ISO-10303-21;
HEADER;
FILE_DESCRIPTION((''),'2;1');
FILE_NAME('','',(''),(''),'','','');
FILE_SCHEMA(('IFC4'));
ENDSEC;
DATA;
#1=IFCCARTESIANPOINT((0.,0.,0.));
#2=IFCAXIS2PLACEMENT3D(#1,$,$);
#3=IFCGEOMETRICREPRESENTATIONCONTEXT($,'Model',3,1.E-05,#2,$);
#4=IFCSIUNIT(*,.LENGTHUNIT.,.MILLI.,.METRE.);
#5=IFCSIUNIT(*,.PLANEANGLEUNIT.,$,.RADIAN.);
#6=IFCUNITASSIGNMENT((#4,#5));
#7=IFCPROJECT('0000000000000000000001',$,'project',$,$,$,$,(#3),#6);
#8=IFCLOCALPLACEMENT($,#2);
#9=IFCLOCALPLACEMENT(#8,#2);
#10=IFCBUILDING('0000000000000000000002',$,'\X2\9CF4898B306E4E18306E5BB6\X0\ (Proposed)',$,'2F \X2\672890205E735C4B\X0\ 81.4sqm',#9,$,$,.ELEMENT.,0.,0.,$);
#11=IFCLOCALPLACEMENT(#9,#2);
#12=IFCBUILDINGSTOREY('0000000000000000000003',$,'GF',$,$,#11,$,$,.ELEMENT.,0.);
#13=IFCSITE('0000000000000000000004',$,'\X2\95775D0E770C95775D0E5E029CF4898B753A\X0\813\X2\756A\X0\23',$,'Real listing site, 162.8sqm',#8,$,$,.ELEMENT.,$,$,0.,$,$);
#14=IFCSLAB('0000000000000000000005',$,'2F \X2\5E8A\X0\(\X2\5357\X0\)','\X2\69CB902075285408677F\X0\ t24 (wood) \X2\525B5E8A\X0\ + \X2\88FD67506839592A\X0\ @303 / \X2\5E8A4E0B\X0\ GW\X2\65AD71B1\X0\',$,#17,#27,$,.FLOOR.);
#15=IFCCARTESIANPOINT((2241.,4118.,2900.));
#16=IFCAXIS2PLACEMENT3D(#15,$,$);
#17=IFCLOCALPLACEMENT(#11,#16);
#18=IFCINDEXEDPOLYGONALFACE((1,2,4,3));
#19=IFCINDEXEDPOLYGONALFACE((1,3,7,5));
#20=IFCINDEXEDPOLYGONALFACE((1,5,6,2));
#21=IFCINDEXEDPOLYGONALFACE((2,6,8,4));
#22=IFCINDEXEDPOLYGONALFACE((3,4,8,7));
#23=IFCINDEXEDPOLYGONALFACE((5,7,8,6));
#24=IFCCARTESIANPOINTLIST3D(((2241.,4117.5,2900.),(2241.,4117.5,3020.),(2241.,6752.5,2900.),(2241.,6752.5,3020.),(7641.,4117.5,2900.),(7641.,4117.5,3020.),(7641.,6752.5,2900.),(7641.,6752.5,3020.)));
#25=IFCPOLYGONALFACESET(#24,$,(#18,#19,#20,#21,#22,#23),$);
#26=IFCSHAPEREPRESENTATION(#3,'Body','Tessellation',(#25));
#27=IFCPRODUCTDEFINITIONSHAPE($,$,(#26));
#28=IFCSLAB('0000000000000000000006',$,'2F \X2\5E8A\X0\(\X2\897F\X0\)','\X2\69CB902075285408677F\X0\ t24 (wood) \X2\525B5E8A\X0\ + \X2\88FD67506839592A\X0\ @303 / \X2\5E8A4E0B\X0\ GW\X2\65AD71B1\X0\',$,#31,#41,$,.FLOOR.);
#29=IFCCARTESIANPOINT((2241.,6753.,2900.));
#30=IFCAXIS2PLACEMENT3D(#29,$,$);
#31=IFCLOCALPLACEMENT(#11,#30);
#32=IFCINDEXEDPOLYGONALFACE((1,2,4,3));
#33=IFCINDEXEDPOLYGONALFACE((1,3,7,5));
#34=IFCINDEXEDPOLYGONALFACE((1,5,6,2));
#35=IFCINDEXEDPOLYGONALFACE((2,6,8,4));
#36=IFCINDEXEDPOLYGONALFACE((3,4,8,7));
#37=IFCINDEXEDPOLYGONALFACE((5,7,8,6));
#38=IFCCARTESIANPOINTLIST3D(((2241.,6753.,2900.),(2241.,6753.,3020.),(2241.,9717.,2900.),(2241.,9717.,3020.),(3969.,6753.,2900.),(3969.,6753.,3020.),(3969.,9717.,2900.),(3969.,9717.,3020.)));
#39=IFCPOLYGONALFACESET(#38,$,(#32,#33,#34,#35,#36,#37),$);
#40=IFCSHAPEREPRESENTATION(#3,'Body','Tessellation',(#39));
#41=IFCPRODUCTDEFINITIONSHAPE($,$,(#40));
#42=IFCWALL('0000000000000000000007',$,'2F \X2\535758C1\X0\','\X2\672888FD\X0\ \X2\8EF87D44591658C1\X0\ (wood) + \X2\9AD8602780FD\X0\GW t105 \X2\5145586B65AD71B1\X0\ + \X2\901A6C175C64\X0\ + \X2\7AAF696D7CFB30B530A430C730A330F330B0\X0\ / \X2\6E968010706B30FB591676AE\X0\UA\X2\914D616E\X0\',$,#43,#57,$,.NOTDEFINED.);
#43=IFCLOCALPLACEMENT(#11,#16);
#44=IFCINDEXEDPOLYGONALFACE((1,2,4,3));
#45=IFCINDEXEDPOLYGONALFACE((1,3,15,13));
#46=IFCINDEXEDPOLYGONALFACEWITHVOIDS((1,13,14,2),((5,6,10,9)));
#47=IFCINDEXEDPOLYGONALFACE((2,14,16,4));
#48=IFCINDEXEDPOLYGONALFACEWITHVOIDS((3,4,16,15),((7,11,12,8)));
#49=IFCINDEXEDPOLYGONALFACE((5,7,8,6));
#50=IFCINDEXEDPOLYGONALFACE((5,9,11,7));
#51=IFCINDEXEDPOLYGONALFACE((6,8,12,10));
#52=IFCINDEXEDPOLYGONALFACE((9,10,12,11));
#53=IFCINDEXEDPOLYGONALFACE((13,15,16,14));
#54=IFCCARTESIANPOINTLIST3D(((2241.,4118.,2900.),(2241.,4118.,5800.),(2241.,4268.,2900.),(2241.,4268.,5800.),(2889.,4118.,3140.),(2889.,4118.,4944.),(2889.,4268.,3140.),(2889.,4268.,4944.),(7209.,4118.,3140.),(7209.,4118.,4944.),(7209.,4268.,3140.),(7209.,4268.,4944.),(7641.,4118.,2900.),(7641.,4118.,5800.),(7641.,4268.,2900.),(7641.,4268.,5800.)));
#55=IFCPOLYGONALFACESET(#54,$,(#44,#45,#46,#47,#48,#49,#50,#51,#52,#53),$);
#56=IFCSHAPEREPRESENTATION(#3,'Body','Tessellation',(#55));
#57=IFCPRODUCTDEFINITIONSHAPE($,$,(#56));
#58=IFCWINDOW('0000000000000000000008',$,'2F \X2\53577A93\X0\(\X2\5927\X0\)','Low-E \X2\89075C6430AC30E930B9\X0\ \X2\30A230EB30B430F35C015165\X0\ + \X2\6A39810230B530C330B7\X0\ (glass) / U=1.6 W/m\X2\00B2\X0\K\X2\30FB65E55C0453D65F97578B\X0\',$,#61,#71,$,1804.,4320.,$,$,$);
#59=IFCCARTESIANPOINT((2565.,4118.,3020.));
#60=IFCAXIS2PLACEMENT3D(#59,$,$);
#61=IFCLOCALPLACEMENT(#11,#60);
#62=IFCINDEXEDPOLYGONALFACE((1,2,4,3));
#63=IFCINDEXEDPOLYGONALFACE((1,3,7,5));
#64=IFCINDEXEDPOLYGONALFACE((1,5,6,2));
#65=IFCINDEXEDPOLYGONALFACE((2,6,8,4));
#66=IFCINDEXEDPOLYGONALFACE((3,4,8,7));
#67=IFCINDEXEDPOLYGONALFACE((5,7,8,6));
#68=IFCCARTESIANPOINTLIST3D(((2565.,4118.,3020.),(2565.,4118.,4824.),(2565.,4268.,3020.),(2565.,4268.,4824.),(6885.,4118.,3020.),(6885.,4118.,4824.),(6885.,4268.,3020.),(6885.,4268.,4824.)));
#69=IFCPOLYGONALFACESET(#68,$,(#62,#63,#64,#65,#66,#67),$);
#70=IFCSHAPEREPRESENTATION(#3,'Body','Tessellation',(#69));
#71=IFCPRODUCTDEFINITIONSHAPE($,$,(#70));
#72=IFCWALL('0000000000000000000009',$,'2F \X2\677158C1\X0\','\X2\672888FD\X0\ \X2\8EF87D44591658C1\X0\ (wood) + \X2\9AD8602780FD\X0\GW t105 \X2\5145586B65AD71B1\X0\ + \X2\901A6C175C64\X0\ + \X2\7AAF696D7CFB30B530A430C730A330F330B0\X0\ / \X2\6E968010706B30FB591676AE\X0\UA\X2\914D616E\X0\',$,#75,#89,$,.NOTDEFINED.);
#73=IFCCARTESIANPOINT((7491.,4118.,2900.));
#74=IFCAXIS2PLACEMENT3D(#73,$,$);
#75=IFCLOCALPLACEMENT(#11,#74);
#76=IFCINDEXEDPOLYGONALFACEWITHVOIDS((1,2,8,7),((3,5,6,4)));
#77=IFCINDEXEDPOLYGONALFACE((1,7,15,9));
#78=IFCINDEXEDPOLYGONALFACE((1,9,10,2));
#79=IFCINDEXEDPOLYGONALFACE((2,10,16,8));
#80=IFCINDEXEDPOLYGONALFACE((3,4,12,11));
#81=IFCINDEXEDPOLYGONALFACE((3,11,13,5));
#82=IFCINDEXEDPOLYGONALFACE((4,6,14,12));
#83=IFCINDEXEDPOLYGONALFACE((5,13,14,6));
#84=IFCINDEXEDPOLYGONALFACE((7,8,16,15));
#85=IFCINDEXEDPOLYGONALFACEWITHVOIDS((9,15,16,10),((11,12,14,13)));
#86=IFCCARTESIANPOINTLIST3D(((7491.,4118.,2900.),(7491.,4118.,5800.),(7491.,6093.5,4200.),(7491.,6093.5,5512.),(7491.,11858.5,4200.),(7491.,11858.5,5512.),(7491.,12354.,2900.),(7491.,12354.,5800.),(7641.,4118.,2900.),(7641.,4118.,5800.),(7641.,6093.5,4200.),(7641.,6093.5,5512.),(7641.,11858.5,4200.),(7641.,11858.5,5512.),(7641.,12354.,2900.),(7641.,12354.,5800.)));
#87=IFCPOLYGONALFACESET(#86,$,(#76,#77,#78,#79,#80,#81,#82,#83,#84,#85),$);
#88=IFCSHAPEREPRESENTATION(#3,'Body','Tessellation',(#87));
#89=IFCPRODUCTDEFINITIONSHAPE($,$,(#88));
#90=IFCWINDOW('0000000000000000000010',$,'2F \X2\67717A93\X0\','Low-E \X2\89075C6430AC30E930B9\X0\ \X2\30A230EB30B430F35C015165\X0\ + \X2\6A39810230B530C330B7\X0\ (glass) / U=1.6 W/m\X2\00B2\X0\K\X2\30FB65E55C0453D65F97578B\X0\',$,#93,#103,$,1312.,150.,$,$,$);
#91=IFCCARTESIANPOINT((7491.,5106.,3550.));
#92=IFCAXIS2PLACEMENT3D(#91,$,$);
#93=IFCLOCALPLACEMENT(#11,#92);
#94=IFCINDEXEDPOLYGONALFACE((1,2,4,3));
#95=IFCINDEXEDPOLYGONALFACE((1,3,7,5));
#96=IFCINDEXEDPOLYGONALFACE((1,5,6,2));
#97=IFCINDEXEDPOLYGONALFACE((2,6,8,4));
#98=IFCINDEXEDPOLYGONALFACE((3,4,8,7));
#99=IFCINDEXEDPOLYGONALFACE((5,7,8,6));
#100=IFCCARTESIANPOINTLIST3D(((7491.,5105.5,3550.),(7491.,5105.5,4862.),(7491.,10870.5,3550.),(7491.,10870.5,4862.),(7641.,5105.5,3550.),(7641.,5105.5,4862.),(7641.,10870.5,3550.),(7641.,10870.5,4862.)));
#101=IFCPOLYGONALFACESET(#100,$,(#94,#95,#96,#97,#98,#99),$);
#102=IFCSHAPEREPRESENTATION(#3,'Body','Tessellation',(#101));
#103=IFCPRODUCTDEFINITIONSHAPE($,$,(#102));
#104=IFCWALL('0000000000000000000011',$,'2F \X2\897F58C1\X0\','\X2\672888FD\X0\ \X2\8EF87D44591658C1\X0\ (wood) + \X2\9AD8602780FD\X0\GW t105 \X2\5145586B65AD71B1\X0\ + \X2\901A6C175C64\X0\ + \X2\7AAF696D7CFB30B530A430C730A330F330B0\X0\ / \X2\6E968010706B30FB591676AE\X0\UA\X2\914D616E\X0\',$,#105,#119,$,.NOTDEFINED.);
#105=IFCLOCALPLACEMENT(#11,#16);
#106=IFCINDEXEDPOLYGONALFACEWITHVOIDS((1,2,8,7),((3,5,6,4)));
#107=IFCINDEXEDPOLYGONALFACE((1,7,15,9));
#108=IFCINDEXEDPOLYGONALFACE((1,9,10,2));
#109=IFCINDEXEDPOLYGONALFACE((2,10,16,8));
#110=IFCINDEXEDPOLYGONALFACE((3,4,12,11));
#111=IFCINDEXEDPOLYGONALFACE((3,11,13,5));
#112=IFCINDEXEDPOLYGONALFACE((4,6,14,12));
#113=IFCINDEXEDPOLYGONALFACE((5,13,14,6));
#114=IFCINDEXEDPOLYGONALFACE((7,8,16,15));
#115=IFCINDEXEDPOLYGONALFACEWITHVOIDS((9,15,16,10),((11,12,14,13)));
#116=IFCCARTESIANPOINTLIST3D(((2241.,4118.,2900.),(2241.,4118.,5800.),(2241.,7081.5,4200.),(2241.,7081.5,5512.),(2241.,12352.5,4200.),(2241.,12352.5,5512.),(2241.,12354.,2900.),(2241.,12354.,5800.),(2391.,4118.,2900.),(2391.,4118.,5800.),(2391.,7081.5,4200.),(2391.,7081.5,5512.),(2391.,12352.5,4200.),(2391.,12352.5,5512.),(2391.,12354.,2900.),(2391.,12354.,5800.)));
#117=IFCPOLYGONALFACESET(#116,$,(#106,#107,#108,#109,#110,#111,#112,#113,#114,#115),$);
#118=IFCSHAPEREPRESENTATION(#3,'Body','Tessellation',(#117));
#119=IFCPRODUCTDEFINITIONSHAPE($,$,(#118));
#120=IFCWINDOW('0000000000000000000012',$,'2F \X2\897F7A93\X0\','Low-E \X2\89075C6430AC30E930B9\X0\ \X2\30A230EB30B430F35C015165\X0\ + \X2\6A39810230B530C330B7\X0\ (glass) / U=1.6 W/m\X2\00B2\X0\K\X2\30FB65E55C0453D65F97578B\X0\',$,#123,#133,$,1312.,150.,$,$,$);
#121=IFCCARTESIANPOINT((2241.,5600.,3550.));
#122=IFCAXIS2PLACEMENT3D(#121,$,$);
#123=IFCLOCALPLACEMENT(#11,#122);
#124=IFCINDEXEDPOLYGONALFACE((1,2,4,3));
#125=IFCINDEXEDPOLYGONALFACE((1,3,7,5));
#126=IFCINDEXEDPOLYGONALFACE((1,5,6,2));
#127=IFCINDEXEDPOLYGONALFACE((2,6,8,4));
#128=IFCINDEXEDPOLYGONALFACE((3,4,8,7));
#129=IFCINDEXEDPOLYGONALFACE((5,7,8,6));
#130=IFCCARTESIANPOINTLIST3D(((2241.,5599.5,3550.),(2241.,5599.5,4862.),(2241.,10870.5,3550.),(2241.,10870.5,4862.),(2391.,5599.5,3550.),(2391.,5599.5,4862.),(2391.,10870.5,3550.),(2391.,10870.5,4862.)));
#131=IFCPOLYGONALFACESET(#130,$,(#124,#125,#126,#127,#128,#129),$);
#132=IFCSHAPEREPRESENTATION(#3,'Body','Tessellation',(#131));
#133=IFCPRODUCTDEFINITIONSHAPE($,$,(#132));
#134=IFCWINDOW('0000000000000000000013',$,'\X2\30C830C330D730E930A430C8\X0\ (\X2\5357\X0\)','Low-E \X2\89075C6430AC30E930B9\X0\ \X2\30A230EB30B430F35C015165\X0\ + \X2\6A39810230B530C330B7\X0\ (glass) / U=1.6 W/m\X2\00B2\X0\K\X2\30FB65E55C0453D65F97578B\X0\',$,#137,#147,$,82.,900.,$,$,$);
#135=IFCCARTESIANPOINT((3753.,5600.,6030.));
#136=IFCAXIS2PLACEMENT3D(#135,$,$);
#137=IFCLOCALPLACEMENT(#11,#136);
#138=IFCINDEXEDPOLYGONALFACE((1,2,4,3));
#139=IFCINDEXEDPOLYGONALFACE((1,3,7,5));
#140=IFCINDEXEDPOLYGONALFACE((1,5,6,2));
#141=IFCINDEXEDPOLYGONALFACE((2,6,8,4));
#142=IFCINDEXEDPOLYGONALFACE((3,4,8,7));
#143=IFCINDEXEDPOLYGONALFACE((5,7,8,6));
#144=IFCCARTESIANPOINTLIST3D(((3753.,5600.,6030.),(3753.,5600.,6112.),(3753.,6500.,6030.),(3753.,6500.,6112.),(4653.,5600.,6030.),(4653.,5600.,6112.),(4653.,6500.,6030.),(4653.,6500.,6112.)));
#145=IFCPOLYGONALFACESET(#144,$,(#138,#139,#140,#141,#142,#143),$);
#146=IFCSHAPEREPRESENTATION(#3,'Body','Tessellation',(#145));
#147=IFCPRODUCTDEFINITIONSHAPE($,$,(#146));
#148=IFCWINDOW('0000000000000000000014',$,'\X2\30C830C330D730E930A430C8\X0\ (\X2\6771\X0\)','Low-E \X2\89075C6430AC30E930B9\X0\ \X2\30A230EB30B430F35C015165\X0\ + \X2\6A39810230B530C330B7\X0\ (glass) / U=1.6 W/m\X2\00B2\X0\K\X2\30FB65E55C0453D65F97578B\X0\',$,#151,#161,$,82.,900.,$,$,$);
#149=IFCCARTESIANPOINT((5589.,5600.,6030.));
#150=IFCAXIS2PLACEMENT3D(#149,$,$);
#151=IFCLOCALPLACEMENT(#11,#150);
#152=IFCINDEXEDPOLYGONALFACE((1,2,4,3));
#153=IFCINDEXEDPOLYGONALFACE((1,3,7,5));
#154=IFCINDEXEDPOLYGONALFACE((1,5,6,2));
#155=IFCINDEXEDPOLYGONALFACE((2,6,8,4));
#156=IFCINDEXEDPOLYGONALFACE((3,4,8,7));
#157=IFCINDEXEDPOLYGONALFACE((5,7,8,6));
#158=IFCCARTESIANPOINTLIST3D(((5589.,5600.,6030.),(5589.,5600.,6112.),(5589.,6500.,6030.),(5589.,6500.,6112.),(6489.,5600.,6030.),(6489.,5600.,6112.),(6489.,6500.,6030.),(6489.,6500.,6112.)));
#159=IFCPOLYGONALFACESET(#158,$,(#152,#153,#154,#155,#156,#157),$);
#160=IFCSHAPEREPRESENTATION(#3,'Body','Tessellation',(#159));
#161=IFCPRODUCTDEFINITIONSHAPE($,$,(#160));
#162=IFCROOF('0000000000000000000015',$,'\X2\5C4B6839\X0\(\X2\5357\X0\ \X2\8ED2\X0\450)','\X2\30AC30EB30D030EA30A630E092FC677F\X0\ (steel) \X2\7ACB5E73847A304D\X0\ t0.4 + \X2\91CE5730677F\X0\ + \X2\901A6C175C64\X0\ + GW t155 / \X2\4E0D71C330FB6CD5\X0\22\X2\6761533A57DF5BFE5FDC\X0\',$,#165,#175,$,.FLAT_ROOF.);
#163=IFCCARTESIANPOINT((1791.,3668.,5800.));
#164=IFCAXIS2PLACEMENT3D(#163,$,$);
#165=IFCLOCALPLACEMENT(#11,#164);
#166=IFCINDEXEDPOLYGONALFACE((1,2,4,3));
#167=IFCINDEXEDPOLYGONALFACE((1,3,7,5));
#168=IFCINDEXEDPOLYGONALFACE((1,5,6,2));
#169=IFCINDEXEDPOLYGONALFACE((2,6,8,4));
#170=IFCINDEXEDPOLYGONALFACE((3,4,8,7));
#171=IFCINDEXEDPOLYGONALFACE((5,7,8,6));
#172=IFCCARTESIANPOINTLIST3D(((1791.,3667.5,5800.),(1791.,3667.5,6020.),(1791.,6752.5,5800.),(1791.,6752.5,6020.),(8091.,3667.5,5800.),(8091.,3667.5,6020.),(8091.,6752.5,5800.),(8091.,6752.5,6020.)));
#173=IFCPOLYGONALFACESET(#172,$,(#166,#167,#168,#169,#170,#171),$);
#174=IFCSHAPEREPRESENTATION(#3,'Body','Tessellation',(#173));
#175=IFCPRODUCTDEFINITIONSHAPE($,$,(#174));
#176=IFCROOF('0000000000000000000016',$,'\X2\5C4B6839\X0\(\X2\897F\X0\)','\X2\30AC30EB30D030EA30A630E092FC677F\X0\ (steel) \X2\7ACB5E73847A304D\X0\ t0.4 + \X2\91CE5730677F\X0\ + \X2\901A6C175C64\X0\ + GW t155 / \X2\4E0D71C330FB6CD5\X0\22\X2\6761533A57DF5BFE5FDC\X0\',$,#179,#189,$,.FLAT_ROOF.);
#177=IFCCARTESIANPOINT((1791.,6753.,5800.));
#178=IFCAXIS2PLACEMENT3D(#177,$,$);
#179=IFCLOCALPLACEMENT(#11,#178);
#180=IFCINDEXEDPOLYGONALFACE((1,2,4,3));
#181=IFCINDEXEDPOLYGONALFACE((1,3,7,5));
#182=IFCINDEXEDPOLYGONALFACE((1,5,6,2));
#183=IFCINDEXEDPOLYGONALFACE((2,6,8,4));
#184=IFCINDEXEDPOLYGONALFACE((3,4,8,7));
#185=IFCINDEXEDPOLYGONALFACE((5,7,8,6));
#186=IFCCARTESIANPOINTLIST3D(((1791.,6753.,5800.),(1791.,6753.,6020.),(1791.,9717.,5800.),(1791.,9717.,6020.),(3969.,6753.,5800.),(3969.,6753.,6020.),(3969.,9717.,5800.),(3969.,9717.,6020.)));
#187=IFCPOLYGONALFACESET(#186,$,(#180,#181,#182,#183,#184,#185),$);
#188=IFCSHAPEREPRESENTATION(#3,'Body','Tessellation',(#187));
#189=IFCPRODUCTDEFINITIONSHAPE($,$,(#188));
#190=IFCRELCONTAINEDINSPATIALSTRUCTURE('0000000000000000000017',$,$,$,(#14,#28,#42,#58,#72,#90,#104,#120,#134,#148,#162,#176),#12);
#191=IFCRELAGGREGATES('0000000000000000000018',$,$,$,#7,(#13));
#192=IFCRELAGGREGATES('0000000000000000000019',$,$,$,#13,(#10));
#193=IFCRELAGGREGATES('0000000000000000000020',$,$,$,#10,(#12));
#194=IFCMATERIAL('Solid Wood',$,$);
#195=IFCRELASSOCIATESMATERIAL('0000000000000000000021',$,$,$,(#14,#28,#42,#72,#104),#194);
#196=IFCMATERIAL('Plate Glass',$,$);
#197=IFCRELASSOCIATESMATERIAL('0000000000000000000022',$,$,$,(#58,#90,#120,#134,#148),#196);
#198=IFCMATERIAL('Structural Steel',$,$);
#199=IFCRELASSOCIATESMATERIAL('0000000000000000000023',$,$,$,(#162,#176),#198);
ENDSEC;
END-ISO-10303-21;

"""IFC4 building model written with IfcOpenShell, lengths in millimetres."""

from ifc_helpers import new_model, si_unit, frame, frame_2d, origin, place, context, project, spatial, rectangle, extrude, material, element, fill, save


model = new_model("IFC4")

# Units and contexts
model_context = context("Model", 3, precision=1e-05, world=origin())
ifc_project = project(units=[si_unit("LENGTHUNIT", "METRE", prefix="MILLI"), si_unit("PLANEANGLEUNIT", "RADIAN")], contexts=[model_context])

# Site, building, storey
site_placement = place(None, origin())
site = spatial("IfcSite", under=ifc_project, at=site_placement, Name="長崎県長崎市鳴見町813番23", ObjectType="Real listing site, 162.8sqm", CompositionType="ELEMENT", RefElevation=0.0)
building_placement = place(site_placement, origin())
building = spatial("IfcBuilding", under=site, at=building_placement, Name="鳴見の丘の家 (Proposed)", ObjectType="2F 木造平屋 81.4sqm", CompositionType="ELEMENT", ElevationOfRefHeight=0.0, ElevationOfTerrain=0.0)
storey_placement = place(building_placement, origin())
storey = spatial("IfcBuildingStorey", under=building, at=storey_placement, Name="GF", CompositionType="ELEMENT", Elevation=0.0)

# Slabs
ifc_material_1 = material(Name="Solid Wood")
slab_1_placement = place(storey_placement, frame((2241.0, 4118.0, 2900.0)))
element("IfcSlab", 1, at=slab_1_placement, inside=storey, material=ifc_material_1, Name="2F 床(南)", Description="構造用合板 t24 (wood) 剛床 + 製材根太 @303 / 床下 GW断熱", PredefinedType="FLOOR", context=model_context, shape_type="SweptSolid", body=[
    extrude(rectangle(XDim=5400.0, YDim=2635.0, at=frame_2d((2700.0, 1317.0))), frame((2241.0, 4118.0, 2900.0)), (0.0, 0.0, 1.0), 120.0),
])
slab_2_placement = place(storey_placement, frame((2241.0, 6753.0, 2900.0)))
element("IfcSlab", 2, at=slab_2_placement, inside=storey, material=ifc_material_1, Name="2F 床(西)", Description="構造用合板 t24 (wood) 剛床 + 製材根太 @303 / 床下 GW断熱", PredefinedType="FLOOR", context=model_context, shape_type="SweptSolid", body=[
    extrude(rectangle(XDim=1728.0, YDim=2964.0, at=frame_2d((864.0, 1482.0))), frame((2241.0, 6753.0, 2900.0)), (0.0, 0.0, 1.0), 120.0),
])

# Walls, openings, windows
wall_1_placement = place(storey_placement, frame((2241.0, 4118.0, 2900.0)))
wall_1 = element("IfcWall", 3, at=wall_1_placement, inside=storey, material=ifc_material_1, Name="2F 南壁", Description="木製 軸組外壁 (wood) + 高性能GW t105 充填断熱 + 通気層 + 窯業系サイディング / 準耐火・外皮UA配慮", PredefinedType="NOTDEFINED", context=model_context, shape_type="SweptSolid", body=[
    extrude(rectangle(XDim=5400.0, YDim=150.0, at=frame_2d((2700.0, 75.0))), frame((2241.0, 4118.0, 2900.0)), (0.0, 0.0, 1.0), 2900.0),
])
opening_1_placement = place(storey_placement, frame((2565.0, 4118.0, 3020.0)))
opening_1 = element("IfcOpeningElement", 4, at=opening_1_placement, cuts=wall_1, PredefinedType="NOTDEFINED", context=model_context, shape_type="SweptSolid", body=[
    extrude(rectangle(XDim=4320.0, YDim=150.0, at=frame_2d((2160.0, 75.0))), frame((2565.0, 4118.0, 3020.0)), (0.0, 0.0, 1.0), 1804.0),
])
ifc_material_2 = material(Name="Plate Glass")
window_1_placement = place(storey_placement, frame((2565.0, 4118.0, 3020.0)))
window_1 = element("IfcWindow", 5, at=window_1_placement, inside=storey, material=ifc_material_2, Name="2F 南窓(大)", Description="Low-E 複層ガラス アルゴン封入 + 樹脂サッシ (glass) / U=1.6 W/m²K・日射取得型", OverallHeight=1804.0, OverallWidth=4320.0, context=model_context, shape_type="SweptSolid", body=[
    extrude(rectangle(XDim=4320.0, YDim=150.0, at=frame_2d((2160.0, 75.0))), frame((2565.0, 4118.0, 3020.0)), (0.0, 0.0, 1.0), 1804.0),
])
fill(opening_1, window_1)
wall_2_placement = place(storey_placement, frame((7491.0, 4118.0, 2900.0)))
wall_2 = element("IfcWall", 6, at=wall_2_placement, inside=storey, material=ifc_material_1, Name="2F 東壁", Description="木製 軸組外壁 (wood) + 高性能GW t105 充填断熱 + 通気層 + 窯業系サイディング / 準耐火・外皮UA配慮", PredefinedType="NOTDEFINED", context=model_context, shape_type="SweptSolid", body=[
    extrude(rectangle(XDim=150.0, YDim=8236.0, at=frame_2d((75.0, 4118.0))), frame((7491.0, 4118.0, 2900.0)), (0.0, 0.0, 1.0), 2900.0),
])
opening_2_placement = place(storey_placement, frame((7491.0, 5106.0, 3550.0)))
opening_2 = element("IfcOpeningElement", 7, at=opening_2_placement, cuts=wall_2, PredefinedType="NOTDEFINED", context=model_context, shape_type="SweptSolid", body=[
    extrude(rectangle(XDim=150.0, YDim=5765.0, at=frame_2d((75.0, 2882.0))), frame((7491.0, 5106.0, 3550.0)), (0.0, 0.0, 1.0), 1312.0),
])
window_2_placement = place(storey_placement, frame((7491.0, 5106.0, 3550.0)))
window_2 = element("IfcWindow", 8, at=window_2_placement, inside=storey, material=ifc_material_2, Name="2F 東窓", Description="Low-E 複層ガラス アルゴン封入 + 樹脂サッシ (glass) / U=1.6 W/m²K・日射取得型", OverallHeight=1312.0, OverallWidth=150.0, context=model_context, shape_type="SweptSolid", body=[
    extrude(rectangle(XDim=150.0, YDim=5765.0, at=frame_2d((75.0, 2882.0))), frame((7491.0, 5106.0, 3550.0)), (0.0, 0.0, 1.0), 1312.0),
])
fill(opening_2, window_2)
wall_3_placement = place(storey_placement, frame((2241.0, 4118.0, 2900.0)))
wall_3 = element("IfcWall", 9, at=wall_3_placement, inside=storey, material=ifc_material_1, Name="2F 西壁", Description="木製 軸組外壁 (wood) + 高性能GW t105 充填断熱 + 通気層 + 窯業系サイディング / 準耐火・外皮UA配慮", PredefinedType="NOTDEFINED", context=model_context, shape_type="SweptSolid", body=[
    extrude(rectangle(XDim=150.0, YDim=8236.0, at=frame_2d((75.0, 4118.0))), frame((2241.0, 4118.0, 2900.0)), (0.0, 0.0, 1.0), 2900.0),
])
opening_3_placement = place(storey_placement, frame((2241.0, 5600.0, 3550.0)))
opening_3 = element("IfcOpeningElement", 10, at=opening_3_placement, cuts=wall_3, PredefinedType="NOTDEFINED", context=model_context, shape_type="SweptSolid", body=[
    extrude(rectangle(XDim=150.0, YDim=5271.0, at=frame_2d((75.0, 2635.0))), frame((2241.0, 5600.0, 3550.0)), (0.0, 0.0, 1.0), 1312.0),
])
window_3_placement = place(storey_placement, frame((2241.0, 5600.0, 3550.0)))
window_3 = element("IfcWindow", 11, at=window_3_placement, inside=storey, material=ifc_material_2, Name="2F 西窓", Description="Low-E 複層ガラス アルゴン封入 + 樹脂サッシ (glass) / U=1.6 W/m²K・日射取得型", OverallHeight=1312.0, OverallWidth=150.0, context=model_context, shape_type="SweptSolid", body=[
    extrude(rectangle(XDim=150.0, YDim=5271.0, at=frame_2d((75.0, 2635.0))), frame((2241.0, 5600.0, 3550.0)), (0.0, 0.0, 1.0), 1312.0),
])
fill(opening_3, window_3)

# Windows
window_4_placement = place(storey_placement, frame((3753.0, 5600.0, 6030.0)))
element("IfcWindow", 12, at=window_4_placement, inside=storey, material=ifc_material_2, Name="トップライト (南)", Description="Low-E 複層ガラス アルゴン封入 + 樹脂サッシ (glass) / U=1.6 W/m²K・日射取得型", OverallHeight=82.0, OverallWidth=900.0, context=model_context, shape_type="SweptSolid", body=[
    extrude(rectangle(XDim=900.0, YDim=900.0, at=frame_2d((450.0, 450.0))), frame((3753.0, 5600.0, 6030.0)), (0.0, 0.0, 1.0), 82.0),
])
window_5_placement = place(storey_placement, frame((5589.0, 5600.0, 6030.0)))
element("IfcWindow", 13, at=window_5_placement, inside=storey, material=ifc_material_2, Name="トップライト (東)", Description="Low-E 複層ガラス アルゴン封入 + 樹脂サッシ (glass) / U=1.6 W/m²K・日射取得型", OverallHeight=82.0, OverallWidth=900.0, context=model_context, shape_type="SweptSolid", body=[
    extrude(rectangle(XDim=900.0, YDim=900.0, at=frame_2d((450.0, 450.0))), frame((5589.0, 5600.0, 6030.0)), (0.0, 0.0, 1.0), 82.0),
])

# Roofs
ifc_material_3 = material(Name="Structural Steel")
roof_1_placement = place(storey_placement, frame((1791.0, 3668.0, 5800.0)))
element("IfcRoof", 14, at=roof_1_placement, inside=storey, material=ifc_material_3, Name="屋根(南 軒450)", Description="ガルバリウム鋼板 (steel) 立平葺き t0.4 + 野地板 + 通気層 + GW t155 / 不燃・法22条区域対応", PredefinedType="FLAT_ROOF", context=model_context, shape_type="SweptSolid", body=[
    extrude(rectangle(XDim=6300.0, YDim=3085.0, at=frame_2d((3150.0, 1542.0))), frame((1791.0, 3668.0, 5800.0)), (0.0, 0.0, 1.0), 220.0),
])
roof_2_placement = place(storey_placement, frame((1791.0, 6753.0, 5800.0)))
element("IfcRoof", 15, at=roof_2_placement, inside=storey, material=ifc_material_3, Name="屋根(西)", Description="ガルバリウム鋼板 (steel) 立平葺き t0.4 + 野地板 + 通気層 + GW t155 / 不燃・法22条区域対応", PredefinedType="FLAT_ROOF", context=model_context, shape_type="SweptSolid", body=[
    extrude(rectangle(XDim=2178.0, YDim=2964.0, at=frame_2d((1089.0, 1482.0))), frame((1791.0, 6753.0, 5800.0)), (0.0, 0.0, 1.0), 220.0),
])

save(model, "model.ifc")
